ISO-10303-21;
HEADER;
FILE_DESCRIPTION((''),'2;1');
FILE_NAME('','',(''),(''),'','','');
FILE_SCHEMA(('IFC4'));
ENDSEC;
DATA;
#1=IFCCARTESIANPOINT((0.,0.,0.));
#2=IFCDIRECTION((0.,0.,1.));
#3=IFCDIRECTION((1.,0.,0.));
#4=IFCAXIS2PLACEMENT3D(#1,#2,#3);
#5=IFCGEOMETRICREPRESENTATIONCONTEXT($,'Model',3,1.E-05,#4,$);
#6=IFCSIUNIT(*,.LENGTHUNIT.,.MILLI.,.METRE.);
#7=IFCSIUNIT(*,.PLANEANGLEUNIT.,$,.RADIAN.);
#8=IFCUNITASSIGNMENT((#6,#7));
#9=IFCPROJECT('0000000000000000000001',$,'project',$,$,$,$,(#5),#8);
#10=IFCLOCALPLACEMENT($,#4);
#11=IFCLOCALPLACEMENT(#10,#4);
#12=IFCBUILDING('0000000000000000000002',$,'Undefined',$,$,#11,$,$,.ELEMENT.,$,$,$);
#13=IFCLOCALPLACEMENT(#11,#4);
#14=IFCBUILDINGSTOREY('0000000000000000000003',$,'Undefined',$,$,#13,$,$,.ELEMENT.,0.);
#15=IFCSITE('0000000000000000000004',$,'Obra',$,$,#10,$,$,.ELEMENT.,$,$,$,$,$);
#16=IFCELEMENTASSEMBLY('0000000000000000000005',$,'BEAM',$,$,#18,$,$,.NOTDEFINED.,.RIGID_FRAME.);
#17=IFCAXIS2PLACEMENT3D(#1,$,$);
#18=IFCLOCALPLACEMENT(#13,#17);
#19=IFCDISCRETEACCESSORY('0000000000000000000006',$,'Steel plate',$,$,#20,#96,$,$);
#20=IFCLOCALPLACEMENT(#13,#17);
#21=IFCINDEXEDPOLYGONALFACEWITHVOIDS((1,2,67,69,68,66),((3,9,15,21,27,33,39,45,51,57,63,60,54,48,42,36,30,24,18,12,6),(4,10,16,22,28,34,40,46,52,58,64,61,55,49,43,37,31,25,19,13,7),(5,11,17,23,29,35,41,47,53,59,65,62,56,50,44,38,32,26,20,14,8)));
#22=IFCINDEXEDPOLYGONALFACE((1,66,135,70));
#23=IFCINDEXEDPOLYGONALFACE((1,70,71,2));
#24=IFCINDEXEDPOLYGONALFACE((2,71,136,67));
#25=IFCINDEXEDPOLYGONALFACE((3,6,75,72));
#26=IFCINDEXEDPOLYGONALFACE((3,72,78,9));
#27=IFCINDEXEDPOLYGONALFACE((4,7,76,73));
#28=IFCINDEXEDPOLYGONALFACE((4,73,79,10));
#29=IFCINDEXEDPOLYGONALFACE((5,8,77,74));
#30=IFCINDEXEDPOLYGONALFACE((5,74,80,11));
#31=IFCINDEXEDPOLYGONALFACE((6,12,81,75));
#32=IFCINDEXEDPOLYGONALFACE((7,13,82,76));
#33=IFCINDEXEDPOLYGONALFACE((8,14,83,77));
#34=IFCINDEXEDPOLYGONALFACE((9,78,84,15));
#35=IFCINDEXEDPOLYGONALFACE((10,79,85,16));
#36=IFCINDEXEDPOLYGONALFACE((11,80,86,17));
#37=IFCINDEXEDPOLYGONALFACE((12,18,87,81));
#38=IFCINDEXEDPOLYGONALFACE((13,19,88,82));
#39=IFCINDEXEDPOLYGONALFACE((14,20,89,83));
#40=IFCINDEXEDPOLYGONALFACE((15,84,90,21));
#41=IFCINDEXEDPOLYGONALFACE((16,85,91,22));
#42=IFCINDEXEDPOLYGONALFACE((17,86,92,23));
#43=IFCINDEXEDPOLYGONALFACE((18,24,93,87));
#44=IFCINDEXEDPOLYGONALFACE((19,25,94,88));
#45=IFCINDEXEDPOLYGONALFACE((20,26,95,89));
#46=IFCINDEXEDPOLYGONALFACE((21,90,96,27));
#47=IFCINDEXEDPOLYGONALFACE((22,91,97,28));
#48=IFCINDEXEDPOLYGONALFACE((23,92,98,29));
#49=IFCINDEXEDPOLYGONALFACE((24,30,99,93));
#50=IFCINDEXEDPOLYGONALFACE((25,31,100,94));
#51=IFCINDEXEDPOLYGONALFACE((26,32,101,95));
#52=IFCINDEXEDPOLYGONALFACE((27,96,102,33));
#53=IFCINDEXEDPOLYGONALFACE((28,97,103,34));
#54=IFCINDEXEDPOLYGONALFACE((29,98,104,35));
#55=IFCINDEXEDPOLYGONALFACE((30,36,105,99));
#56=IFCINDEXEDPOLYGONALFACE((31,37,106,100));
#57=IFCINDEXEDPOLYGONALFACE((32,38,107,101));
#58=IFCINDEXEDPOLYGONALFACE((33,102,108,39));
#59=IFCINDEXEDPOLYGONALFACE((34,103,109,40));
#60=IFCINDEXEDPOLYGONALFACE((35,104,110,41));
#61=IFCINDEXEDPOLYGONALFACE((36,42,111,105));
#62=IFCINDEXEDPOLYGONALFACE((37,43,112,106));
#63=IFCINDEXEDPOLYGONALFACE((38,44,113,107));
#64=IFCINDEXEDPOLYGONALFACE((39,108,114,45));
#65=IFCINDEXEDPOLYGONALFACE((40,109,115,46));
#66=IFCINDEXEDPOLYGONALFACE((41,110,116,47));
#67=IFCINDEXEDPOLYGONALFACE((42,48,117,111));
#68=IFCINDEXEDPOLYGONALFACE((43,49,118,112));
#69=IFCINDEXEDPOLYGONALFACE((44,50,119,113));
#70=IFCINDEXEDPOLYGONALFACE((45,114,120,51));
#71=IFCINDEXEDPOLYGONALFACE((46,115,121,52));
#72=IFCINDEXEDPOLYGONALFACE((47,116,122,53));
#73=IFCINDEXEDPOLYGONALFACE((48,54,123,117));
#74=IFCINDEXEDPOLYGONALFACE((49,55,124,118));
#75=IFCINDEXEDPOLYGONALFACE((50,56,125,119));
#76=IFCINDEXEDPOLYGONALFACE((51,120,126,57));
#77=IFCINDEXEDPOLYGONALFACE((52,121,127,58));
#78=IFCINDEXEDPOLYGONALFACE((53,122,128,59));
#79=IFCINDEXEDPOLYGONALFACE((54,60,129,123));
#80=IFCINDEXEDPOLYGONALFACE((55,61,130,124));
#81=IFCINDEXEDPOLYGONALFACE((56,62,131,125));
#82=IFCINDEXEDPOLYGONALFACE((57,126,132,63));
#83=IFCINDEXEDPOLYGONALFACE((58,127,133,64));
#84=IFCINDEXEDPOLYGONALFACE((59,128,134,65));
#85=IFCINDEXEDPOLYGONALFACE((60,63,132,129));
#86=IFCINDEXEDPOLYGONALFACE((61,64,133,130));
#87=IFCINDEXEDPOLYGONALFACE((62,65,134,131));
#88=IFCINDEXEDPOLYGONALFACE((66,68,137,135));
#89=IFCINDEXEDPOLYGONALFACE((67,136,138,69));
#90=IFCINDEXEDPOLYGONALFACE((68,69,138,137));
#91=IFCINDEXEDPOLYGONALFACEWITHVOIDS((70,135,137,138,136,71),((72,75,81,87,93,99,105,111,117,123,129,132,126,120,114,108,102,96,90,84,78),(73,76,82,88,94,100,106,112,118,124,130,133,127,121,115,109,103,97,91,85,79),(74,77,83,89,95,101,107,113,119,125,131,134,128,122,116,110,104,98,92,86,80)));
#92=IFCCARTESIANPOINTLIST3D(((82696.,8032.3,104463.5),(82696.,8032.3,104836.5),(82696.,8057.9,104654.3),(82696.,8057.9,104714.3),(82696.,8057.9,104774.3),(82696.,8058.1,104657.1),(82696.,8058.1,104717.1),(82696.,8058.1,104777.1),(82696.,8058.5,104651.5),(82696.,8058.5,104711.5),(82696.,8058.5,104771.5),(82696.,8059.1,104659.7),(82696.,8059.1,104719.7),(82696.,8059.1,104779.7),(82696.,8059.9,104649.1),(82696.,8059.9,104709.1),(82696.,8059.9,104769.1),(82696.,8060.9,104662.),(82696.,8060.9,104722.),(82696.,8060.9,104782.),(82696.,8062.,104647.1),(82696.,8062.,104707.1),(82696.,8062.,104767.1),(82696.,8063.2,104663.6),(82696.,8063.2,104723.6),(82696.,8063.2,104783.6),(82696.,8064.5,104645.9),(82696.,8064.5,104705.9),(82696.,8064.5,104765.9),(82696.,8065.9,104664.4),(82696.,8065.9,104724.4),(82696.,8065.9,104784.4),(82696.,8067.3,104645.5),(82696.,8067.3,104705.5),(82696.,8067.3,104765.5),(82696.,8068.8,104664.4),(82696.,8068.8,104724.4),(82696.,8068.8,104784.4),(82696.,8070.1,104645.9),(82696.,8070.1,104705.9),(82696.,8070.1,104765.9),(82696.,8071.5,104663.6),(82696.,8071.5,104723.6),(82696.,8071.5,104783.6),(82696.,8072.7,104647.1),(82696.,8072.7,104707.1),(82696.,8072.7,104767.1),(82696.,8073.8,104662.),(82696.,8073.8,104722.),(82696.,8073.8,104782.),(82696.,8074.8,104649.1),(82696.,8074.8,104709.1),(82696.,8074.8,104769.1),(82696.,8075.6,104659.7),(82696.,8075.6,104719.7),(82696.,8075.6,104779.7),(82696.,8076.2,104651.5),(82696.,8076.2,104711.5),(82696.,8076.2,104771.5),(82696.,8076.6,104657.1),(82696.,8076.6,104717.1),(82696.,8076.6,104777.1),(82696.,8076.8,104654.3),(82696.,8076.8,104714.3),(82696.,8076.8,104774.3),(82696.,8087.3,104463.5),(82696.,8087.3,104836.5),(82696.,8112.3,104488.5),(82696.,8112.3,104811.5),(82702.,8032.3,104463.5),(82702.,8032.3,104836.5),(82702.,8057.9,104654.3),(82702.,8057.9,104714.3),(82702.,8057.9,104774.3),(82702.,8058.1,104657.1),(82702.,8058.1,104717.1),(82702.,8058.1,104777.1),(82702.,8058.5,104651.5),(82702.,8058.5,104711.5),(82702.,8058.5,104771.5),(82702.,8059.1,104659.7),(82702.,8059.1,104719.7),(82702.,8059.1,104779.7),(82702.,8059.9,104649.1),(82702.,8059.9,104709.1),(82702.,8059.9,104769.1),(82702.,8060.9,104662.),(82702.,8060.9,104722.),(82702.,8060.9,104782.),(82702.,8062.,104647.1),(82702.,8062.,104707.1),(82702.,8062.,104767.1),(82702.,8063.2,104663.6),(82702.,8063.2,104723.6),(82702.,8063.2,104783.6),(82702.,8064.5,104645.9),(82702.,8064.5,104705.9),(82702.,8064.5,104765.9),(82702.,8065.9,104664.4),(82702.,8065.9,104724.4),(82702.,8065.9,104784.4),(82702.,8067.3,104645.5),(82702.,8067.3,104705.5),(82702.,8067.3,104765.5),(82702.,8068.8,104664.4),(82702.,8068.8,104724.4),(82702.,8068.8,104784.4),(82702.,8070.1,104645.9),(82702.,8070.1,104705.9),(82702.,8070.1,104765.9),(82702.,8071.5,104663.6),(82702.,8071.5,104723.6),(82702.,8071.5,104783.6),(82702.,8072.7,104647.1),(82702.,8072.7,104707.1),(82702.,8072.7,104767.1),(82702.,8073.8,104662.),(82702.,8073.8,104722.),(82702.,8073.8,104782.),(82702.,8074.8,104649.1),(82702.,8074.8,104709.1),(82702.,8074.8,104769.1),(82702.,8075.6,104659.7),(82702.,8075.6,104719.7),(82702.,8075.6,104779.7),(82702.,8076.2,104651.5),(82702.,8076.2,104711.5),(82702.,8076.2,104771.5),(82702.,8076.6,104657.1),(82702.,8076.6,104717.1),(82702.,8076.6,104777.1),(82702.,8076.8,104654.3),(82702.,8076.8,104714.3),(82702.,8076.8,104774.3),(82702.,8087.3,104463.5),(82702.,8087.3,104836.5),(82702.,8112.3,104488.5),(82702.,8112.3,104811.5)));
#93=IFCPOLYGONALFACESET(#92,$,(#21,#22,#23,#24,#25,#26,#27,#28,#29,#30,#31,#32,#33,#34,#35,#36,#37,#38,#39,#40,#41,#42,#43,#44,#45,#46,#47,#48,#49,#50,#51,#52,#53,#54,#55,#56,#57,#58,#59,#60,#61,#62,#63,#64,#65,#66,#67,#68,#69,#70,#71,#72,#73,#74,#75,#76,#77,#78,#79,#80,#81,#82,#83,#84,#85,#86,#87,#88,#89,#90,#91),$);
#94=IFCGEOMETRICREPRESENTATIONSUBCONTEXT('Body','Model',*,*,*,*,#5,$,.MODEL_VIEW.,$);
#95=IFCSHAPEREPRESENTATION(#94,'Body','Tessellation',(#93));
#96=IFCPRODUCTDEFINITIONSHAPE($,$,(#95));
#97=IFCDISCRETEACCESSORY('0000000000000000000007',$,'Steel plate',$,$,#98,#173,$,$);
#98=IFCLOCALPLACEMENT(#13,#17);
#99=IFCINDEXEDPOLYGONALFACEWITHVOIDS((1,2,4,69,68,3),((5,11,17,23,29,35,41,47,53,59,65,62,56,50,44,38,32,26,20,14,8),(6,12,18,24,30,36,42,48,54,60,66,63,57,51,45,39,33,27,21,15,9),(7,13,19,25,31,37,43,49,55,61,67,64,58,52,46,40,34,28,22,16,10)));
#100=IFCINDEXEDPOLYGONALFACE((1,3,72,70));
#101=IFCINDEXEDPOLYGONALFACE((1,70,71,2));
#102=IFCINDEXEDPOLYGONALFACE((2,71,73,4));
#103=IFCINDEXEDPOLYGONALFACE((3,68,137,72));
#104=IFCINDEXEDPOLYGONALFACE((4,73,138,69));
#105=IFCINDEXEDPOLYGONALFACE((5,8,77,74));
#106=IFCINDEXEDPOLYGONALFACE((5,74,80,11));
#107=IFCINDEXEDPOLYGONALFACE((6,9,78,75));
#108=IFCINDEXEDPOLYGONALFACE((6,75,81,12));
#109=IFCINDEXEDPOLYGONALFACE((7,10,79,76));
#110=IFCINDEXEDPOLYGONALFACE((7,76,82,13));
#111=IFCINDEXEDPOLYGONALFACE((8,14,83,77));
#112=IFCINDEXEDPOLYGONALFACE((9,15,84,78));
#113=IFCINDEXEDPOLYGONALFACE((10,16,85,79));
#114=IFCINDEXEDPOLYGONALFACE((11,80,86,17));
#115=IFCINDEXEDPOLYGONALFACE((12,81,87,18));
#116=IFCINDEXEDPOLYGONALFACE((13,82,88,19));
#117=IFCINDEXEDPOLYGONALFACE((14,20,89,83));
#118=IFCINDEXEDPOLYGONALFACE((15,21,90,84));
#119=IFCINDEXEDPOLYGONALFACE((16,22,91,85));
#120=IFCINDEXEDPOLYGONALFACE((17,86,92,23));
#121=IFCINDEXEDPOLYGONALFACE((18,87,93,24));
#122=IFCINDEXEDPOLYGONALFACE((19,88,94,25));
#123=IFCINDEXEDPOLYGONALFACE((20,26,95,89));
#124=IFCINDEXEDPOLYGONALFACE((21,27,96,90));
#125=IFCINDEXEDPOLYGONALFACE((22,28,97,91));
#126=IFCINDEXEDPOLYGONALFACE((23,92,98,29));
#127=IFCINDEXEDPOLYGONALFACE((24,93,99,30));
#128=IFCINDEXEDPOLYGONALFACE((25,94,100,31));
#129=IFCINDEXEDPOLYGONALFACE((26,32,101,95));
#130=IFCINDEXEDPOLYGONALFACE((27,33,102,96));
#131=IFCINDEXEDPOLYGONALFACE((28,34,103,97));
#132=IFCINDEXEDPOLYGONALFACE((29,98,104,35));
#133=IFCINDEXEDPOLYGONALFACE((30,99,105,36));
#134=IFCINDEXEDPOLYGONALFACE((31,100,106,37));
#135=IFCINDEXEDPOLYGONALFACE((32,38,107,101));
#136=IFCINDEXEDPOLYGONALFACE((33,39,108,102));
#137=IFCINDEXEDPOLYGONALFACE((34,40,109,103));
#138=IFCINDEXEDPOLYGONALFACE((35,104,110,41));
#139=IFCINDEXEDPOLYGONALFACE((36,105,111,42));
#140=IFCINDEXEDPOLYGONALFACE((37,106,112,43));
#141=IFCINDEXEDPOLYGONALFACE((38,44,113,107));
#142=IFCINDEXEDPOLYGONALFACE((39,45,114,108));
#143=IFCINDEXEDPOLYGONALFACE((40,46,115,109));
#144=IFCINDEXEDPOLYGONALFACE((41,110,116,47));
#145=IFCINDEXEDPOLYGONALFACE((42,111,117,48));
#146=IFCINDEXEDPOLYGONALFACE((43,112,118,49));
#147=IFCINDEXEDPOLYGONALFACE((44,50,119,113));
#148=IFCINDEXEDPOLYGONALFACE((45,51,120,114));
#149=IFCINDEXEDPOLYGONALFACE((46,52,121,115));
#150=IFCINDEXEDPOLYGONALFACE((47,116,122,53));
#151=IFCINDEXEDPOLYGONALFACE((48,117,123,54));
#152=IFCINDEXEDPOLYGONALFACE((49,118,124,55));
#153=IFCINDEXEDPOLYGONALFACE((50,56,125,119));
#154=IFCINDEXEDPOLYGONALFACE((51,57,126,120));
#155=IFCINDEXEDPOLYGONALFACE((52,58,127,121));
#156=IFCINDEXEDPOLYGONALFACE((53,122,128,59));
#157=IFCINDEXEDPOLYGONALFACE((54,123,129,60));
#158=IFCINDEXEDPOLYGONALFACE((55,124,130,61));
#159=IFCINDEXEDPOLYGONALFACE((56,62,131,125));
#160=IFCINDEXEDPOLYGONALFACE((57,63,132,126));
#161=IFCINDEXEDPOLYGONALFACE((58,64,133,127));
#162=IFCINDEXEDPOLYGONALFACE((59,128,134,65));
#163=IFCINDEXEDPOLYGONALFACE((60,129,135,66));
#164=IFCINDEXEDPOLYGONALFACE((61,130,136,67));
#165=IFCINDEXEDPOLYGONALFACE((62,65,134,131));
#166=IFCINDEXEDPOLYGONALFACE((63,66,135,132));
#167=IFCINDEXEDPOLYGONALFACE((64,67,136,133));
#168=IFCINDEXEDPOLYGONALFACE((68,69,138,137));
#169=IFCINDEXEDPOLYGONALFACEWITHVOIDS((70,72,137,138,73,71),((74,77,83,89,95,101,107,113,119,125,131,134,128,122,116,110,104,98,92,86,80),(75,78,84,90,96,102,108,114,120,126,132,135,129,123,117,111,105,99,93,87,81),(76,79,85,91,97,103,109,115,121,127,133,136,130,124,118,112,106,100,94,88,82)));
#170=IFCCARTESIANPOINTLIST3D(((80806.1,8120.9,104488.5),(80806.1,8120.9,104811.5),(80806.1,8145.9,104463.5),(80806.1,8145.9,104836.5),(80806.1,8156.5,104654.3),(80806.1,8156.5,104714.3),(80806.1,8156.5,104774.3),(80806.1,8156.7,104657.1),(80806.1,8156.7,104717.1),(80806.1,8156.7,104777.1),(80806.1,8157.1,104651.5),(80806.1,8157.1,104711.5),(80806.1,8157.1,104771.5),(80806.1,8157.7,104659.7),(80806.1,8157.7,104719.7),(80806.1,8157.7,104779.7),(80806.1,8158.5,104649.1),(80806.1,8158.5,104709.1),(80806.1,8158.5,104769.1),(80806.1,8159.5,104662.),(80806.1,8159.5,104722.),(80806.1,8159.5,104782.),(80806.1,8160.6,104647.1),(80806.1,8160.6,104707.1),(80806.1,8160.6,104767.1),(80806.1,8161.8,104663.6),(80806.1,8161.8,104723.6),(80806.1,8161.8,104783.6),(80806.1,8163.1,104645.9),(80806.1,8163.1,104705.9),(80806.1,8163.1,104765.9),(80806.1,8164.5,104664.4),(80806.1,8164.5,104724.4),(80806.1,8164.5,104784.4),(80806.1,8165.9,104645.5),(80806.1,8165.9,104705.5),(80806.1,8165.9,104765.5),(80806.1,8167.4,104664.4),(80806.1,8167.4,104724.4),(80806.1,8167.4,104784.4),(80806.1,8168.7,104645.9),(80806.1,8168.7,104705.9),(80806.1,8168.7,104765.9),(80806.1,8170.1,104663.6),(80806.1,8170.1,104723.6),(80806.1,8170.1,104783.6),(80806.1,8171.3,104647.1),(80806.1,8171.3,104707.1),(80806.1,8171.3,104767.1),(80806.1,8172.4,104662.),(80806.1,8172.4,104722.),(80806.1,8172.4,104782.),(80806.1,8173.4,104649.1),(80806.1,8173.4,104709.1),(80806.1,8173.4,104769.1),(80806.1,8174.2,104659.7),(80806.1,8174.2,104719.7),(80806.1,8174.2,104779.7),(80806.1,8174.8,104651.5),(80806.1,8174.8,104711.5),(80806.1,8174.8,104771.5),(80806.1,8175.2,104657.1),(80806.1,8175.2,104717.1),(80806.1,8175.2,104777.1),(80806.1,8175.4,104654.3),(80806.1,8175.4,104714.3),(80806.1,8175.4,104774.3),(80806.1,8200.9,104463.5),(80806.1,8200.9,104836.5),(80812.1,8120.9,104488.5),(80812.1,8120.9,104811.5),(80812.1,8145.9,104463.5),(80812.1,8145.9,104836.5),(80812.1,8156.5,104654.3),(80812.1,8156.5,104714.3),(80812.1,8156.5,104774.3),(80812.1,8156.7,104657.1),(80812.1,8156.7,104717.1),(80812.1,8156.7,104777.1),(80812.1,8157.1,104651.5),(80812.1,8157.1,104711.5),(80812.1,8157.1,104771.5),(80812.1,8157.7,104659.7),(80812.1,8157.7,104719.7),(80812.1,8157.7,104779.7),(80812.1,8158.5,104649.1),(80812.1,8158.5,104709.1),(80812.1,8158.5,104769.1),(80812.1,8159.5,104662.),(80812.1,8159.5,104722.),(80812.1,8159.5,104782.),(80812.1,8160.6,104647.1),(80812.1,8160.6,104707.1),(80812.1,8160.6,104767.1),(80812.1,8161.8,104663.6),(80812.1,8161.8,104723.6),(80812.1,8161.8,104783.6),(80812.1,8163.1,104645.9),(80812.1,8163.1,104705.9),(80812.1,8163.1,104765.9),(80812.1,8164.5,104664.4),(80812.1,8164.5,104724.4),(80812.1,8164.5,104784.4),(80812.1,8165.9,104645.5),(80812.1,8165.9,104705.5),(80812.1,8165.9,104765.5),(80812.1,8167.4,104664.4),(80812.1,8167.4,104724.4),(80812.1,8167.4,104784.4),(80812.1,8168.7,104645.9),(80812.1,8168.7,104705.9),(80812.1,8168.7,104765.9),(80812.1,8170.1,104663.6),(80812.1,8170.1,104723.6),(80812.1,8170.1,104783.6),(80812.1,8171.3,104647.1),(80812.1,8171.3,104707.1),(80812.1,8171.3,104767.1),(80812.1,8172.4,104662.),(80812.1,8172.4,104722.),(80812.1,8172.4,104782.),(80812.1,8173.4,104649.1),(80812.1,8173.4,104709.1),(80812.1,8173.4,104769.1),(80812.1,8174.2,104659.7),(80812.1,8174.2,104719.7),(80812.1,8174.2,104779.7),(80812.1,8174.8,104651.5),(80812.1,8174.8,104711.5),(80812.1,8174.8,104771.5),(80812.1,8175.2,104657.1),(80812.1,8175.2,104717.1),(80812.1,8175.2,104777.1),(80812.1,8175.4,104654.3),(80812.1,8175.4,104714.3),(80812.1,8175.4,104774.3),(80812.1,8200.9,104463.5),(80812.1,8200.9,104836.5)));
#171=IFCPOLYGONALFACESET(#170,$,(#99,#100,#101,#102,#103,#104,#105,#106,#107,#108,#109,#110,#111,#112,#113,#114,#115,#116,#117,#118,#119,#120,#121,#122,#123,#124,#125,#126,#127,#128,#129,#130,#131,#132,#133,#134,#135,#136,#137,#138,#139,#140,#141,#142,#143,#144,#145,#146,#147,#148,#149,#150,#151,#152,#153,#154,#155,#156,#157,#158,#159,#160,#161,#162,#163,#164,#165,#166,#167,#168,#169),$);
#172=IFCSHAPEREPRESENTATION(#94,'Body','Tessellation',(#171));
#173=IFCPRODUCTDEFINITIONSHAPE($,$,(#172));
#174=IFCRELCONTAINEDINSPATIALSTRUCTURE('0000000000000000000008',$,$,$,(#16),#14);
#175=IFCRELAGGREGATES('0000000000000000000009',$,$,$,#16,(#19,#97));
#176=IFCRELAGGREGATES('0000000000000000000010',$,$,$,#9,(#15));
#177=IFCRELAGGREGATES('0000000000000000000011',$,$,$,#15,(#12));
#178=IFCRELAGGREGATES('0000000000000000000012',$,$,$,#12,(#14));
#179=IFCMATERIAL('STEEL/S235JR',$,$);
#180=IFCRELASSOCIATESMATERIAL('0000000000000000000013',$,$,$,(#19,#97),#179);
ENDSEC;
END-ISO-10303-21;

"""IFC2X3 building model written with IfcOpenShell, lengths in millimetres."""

from ifc_helpers import new_model, si_unit, frame, origin_with_axes, origin_2d_with_axis, place, context, subcontext, project, spatial, polyline, circle, outline, extrude, source, transform, mapped, material, element, aggregate, save


model = new_model("IFC2X3")

# Units and contexts
model_context = context("Model", 3, precision=1e-05, world=origin_with_axes())
body_context = subcontext(model_context, "Body", "Model", "MODEL_VIEW")
ifc_project = project(units=[si_unit("LENGTHUNIT", "METRE", prefix="MILLI"), si_unit("PLANEANGLEUNIT", "RADIAN")], contexts=[model_context])

# Site, building, storey
site_placement = place(None, origin_with_axes())
site = spatial("IfcSite", under=ifc_project, at=site_placement, Name="Obra", CompositionType="ELEMENT")
building_placement = place(site_placement, origin_with_axes())
building = spatial("IfcBuilding", under=site, at=building_placement, Name="Undefined", CompositionType="ELEMENT")
storey_placement = place(building_placement, origin_with_axes())
storey = spatial("IfcBuildingStorey", under=building, at=storey_placement, Name="Undefined", CompositionType="ELEMENT", Elevation=0.0)

# Shared definitions
ifc_material = material(Name="STEEL/S235JR")

# Shared definitions
shared_shape_1 = source(origin_with_axes(), body_context, "Body", "SweptSolid", [
    extrude(circle(Radius=9.5, at=origin_2d_with_axis()), frame((0.0, -9.4, 0.0), z_axis=(0.0, 1.0, 0.0), x_axis=(1.0, 0.0, 0.0)), (0.0, 0.0, 1.0), 6.2),
])

# Element assembly, discrete accessories, openings
assembly_1_placement = place(storey_placement, origin_with_axes())
assembly_1 = element("IfcElementAssembly", 1, at=assembly_1_placement, inside=storey, Name="BEAM", AssemblyPlace="NOTDEFINED", PredefinedType="RIGID_FRAME")
discrete_accessory_1_placement = place(assembly_1_placement, frame((82699.0, 8032.3, 104463.5), z_axis=(1.0, 0.0, 0.0), x_axis=(0.0, 1.0, 0.0)))
discrete_accessory_1 = element("IfcDiscreteAccessory", 2, at=discrete_accessory_1_placement, material=ifc_material, Name="Steel plate", context=body_context, shape_type="SweptSolid", body=[
    extrude(outline(polyline([(0.0, 0.0), (55.0, 0.0), (80.0, 25.0), (80.0, 348.0), (55.0, 373.0), (0.0, 373.0), (0.0, 0.0)])), frame((0.0, 0.0, -3.0), z_axis=(0.0, 0.0, 1.0), x_axis=(1.0, 0.0, 0.0)), (0.0, 0.0, 1.0), 6.0),
])
opening_1_placement = place(assembly_1_placement, frame((82705.3, 8102.3, 104850.0), z_axis=(0.0, -1.0, 0.0), x_axis=(0.0, 0.0, -1.0)))
element("IfcOpeningElement", 3, at=opening_1_placement, cuts=discrete_accessory_1, ObjectType="Opening", context=body_context, shape_type="MappedRepresentation", body=[
    mapped(shared_shape_1, transform((75.0, 0.0, 35.0))),
    mapped(shared_shape_1, transform((135.0, 0.0, 35.0))),
    mapped(shared_shape_1, transform((195.0, 0.0, 35.0))),
])
discrete_accessory_2_placement = place(assembly_1_placement, frame((80809.1, 8200.9, 104463.5), z_axis=(-1.0, 0.0, 0.0), x_axis=(0.0, -1.0, 0.0)))
discrete_accessory_2 = element("IfcDiscreteAccessory", 4, at=discrete_accessory_2_placement, material=ifc_material, Name="Steel plate", context=body_context, shape_type="SweptSolid", body=[
    extrude(outline(polyline([(0.0, 0.0), (55.0, 0.0), (80.0, 25.0), (80.0, 348.0), (55.0, 373.0), (0.0, 373.0), (0.0, 0.0)])), frame((0.0, 0.0, -3.0), z_axis=(0.0, 0.0, 1.0), x_axis=(1.0, 0.0, 0.0)), (0.0, 0.0, 1.0), 6.0),
])
opening_2_placement = place(assembly_1_placement, frame((80802.8, 8130.9, 104850.0), z_axis=(0.0, 1.0, 0.0), x_axis=(0.0, 0.0, -1.0)))
element("IfcOpeningElement", 5, at=opening_2_placement, cuts=discrete_accessory_2, ObjectType="Opening", context=body_context, shape_type="MappedRepresentation", body=[
    mapped(shared_shape_1, transform((75.0, 0.0, 35.0))),
    mapped(shared_shape_1, transform((135.0, 0.0, 35.0))),
    mapped(shared_shape_1, transform((195.0, 0.0, 35.0))),
])

aggregate(assembly_1, [discrete_accessory_1, discrete_accessory_2])

save(model, "model.ifc")
